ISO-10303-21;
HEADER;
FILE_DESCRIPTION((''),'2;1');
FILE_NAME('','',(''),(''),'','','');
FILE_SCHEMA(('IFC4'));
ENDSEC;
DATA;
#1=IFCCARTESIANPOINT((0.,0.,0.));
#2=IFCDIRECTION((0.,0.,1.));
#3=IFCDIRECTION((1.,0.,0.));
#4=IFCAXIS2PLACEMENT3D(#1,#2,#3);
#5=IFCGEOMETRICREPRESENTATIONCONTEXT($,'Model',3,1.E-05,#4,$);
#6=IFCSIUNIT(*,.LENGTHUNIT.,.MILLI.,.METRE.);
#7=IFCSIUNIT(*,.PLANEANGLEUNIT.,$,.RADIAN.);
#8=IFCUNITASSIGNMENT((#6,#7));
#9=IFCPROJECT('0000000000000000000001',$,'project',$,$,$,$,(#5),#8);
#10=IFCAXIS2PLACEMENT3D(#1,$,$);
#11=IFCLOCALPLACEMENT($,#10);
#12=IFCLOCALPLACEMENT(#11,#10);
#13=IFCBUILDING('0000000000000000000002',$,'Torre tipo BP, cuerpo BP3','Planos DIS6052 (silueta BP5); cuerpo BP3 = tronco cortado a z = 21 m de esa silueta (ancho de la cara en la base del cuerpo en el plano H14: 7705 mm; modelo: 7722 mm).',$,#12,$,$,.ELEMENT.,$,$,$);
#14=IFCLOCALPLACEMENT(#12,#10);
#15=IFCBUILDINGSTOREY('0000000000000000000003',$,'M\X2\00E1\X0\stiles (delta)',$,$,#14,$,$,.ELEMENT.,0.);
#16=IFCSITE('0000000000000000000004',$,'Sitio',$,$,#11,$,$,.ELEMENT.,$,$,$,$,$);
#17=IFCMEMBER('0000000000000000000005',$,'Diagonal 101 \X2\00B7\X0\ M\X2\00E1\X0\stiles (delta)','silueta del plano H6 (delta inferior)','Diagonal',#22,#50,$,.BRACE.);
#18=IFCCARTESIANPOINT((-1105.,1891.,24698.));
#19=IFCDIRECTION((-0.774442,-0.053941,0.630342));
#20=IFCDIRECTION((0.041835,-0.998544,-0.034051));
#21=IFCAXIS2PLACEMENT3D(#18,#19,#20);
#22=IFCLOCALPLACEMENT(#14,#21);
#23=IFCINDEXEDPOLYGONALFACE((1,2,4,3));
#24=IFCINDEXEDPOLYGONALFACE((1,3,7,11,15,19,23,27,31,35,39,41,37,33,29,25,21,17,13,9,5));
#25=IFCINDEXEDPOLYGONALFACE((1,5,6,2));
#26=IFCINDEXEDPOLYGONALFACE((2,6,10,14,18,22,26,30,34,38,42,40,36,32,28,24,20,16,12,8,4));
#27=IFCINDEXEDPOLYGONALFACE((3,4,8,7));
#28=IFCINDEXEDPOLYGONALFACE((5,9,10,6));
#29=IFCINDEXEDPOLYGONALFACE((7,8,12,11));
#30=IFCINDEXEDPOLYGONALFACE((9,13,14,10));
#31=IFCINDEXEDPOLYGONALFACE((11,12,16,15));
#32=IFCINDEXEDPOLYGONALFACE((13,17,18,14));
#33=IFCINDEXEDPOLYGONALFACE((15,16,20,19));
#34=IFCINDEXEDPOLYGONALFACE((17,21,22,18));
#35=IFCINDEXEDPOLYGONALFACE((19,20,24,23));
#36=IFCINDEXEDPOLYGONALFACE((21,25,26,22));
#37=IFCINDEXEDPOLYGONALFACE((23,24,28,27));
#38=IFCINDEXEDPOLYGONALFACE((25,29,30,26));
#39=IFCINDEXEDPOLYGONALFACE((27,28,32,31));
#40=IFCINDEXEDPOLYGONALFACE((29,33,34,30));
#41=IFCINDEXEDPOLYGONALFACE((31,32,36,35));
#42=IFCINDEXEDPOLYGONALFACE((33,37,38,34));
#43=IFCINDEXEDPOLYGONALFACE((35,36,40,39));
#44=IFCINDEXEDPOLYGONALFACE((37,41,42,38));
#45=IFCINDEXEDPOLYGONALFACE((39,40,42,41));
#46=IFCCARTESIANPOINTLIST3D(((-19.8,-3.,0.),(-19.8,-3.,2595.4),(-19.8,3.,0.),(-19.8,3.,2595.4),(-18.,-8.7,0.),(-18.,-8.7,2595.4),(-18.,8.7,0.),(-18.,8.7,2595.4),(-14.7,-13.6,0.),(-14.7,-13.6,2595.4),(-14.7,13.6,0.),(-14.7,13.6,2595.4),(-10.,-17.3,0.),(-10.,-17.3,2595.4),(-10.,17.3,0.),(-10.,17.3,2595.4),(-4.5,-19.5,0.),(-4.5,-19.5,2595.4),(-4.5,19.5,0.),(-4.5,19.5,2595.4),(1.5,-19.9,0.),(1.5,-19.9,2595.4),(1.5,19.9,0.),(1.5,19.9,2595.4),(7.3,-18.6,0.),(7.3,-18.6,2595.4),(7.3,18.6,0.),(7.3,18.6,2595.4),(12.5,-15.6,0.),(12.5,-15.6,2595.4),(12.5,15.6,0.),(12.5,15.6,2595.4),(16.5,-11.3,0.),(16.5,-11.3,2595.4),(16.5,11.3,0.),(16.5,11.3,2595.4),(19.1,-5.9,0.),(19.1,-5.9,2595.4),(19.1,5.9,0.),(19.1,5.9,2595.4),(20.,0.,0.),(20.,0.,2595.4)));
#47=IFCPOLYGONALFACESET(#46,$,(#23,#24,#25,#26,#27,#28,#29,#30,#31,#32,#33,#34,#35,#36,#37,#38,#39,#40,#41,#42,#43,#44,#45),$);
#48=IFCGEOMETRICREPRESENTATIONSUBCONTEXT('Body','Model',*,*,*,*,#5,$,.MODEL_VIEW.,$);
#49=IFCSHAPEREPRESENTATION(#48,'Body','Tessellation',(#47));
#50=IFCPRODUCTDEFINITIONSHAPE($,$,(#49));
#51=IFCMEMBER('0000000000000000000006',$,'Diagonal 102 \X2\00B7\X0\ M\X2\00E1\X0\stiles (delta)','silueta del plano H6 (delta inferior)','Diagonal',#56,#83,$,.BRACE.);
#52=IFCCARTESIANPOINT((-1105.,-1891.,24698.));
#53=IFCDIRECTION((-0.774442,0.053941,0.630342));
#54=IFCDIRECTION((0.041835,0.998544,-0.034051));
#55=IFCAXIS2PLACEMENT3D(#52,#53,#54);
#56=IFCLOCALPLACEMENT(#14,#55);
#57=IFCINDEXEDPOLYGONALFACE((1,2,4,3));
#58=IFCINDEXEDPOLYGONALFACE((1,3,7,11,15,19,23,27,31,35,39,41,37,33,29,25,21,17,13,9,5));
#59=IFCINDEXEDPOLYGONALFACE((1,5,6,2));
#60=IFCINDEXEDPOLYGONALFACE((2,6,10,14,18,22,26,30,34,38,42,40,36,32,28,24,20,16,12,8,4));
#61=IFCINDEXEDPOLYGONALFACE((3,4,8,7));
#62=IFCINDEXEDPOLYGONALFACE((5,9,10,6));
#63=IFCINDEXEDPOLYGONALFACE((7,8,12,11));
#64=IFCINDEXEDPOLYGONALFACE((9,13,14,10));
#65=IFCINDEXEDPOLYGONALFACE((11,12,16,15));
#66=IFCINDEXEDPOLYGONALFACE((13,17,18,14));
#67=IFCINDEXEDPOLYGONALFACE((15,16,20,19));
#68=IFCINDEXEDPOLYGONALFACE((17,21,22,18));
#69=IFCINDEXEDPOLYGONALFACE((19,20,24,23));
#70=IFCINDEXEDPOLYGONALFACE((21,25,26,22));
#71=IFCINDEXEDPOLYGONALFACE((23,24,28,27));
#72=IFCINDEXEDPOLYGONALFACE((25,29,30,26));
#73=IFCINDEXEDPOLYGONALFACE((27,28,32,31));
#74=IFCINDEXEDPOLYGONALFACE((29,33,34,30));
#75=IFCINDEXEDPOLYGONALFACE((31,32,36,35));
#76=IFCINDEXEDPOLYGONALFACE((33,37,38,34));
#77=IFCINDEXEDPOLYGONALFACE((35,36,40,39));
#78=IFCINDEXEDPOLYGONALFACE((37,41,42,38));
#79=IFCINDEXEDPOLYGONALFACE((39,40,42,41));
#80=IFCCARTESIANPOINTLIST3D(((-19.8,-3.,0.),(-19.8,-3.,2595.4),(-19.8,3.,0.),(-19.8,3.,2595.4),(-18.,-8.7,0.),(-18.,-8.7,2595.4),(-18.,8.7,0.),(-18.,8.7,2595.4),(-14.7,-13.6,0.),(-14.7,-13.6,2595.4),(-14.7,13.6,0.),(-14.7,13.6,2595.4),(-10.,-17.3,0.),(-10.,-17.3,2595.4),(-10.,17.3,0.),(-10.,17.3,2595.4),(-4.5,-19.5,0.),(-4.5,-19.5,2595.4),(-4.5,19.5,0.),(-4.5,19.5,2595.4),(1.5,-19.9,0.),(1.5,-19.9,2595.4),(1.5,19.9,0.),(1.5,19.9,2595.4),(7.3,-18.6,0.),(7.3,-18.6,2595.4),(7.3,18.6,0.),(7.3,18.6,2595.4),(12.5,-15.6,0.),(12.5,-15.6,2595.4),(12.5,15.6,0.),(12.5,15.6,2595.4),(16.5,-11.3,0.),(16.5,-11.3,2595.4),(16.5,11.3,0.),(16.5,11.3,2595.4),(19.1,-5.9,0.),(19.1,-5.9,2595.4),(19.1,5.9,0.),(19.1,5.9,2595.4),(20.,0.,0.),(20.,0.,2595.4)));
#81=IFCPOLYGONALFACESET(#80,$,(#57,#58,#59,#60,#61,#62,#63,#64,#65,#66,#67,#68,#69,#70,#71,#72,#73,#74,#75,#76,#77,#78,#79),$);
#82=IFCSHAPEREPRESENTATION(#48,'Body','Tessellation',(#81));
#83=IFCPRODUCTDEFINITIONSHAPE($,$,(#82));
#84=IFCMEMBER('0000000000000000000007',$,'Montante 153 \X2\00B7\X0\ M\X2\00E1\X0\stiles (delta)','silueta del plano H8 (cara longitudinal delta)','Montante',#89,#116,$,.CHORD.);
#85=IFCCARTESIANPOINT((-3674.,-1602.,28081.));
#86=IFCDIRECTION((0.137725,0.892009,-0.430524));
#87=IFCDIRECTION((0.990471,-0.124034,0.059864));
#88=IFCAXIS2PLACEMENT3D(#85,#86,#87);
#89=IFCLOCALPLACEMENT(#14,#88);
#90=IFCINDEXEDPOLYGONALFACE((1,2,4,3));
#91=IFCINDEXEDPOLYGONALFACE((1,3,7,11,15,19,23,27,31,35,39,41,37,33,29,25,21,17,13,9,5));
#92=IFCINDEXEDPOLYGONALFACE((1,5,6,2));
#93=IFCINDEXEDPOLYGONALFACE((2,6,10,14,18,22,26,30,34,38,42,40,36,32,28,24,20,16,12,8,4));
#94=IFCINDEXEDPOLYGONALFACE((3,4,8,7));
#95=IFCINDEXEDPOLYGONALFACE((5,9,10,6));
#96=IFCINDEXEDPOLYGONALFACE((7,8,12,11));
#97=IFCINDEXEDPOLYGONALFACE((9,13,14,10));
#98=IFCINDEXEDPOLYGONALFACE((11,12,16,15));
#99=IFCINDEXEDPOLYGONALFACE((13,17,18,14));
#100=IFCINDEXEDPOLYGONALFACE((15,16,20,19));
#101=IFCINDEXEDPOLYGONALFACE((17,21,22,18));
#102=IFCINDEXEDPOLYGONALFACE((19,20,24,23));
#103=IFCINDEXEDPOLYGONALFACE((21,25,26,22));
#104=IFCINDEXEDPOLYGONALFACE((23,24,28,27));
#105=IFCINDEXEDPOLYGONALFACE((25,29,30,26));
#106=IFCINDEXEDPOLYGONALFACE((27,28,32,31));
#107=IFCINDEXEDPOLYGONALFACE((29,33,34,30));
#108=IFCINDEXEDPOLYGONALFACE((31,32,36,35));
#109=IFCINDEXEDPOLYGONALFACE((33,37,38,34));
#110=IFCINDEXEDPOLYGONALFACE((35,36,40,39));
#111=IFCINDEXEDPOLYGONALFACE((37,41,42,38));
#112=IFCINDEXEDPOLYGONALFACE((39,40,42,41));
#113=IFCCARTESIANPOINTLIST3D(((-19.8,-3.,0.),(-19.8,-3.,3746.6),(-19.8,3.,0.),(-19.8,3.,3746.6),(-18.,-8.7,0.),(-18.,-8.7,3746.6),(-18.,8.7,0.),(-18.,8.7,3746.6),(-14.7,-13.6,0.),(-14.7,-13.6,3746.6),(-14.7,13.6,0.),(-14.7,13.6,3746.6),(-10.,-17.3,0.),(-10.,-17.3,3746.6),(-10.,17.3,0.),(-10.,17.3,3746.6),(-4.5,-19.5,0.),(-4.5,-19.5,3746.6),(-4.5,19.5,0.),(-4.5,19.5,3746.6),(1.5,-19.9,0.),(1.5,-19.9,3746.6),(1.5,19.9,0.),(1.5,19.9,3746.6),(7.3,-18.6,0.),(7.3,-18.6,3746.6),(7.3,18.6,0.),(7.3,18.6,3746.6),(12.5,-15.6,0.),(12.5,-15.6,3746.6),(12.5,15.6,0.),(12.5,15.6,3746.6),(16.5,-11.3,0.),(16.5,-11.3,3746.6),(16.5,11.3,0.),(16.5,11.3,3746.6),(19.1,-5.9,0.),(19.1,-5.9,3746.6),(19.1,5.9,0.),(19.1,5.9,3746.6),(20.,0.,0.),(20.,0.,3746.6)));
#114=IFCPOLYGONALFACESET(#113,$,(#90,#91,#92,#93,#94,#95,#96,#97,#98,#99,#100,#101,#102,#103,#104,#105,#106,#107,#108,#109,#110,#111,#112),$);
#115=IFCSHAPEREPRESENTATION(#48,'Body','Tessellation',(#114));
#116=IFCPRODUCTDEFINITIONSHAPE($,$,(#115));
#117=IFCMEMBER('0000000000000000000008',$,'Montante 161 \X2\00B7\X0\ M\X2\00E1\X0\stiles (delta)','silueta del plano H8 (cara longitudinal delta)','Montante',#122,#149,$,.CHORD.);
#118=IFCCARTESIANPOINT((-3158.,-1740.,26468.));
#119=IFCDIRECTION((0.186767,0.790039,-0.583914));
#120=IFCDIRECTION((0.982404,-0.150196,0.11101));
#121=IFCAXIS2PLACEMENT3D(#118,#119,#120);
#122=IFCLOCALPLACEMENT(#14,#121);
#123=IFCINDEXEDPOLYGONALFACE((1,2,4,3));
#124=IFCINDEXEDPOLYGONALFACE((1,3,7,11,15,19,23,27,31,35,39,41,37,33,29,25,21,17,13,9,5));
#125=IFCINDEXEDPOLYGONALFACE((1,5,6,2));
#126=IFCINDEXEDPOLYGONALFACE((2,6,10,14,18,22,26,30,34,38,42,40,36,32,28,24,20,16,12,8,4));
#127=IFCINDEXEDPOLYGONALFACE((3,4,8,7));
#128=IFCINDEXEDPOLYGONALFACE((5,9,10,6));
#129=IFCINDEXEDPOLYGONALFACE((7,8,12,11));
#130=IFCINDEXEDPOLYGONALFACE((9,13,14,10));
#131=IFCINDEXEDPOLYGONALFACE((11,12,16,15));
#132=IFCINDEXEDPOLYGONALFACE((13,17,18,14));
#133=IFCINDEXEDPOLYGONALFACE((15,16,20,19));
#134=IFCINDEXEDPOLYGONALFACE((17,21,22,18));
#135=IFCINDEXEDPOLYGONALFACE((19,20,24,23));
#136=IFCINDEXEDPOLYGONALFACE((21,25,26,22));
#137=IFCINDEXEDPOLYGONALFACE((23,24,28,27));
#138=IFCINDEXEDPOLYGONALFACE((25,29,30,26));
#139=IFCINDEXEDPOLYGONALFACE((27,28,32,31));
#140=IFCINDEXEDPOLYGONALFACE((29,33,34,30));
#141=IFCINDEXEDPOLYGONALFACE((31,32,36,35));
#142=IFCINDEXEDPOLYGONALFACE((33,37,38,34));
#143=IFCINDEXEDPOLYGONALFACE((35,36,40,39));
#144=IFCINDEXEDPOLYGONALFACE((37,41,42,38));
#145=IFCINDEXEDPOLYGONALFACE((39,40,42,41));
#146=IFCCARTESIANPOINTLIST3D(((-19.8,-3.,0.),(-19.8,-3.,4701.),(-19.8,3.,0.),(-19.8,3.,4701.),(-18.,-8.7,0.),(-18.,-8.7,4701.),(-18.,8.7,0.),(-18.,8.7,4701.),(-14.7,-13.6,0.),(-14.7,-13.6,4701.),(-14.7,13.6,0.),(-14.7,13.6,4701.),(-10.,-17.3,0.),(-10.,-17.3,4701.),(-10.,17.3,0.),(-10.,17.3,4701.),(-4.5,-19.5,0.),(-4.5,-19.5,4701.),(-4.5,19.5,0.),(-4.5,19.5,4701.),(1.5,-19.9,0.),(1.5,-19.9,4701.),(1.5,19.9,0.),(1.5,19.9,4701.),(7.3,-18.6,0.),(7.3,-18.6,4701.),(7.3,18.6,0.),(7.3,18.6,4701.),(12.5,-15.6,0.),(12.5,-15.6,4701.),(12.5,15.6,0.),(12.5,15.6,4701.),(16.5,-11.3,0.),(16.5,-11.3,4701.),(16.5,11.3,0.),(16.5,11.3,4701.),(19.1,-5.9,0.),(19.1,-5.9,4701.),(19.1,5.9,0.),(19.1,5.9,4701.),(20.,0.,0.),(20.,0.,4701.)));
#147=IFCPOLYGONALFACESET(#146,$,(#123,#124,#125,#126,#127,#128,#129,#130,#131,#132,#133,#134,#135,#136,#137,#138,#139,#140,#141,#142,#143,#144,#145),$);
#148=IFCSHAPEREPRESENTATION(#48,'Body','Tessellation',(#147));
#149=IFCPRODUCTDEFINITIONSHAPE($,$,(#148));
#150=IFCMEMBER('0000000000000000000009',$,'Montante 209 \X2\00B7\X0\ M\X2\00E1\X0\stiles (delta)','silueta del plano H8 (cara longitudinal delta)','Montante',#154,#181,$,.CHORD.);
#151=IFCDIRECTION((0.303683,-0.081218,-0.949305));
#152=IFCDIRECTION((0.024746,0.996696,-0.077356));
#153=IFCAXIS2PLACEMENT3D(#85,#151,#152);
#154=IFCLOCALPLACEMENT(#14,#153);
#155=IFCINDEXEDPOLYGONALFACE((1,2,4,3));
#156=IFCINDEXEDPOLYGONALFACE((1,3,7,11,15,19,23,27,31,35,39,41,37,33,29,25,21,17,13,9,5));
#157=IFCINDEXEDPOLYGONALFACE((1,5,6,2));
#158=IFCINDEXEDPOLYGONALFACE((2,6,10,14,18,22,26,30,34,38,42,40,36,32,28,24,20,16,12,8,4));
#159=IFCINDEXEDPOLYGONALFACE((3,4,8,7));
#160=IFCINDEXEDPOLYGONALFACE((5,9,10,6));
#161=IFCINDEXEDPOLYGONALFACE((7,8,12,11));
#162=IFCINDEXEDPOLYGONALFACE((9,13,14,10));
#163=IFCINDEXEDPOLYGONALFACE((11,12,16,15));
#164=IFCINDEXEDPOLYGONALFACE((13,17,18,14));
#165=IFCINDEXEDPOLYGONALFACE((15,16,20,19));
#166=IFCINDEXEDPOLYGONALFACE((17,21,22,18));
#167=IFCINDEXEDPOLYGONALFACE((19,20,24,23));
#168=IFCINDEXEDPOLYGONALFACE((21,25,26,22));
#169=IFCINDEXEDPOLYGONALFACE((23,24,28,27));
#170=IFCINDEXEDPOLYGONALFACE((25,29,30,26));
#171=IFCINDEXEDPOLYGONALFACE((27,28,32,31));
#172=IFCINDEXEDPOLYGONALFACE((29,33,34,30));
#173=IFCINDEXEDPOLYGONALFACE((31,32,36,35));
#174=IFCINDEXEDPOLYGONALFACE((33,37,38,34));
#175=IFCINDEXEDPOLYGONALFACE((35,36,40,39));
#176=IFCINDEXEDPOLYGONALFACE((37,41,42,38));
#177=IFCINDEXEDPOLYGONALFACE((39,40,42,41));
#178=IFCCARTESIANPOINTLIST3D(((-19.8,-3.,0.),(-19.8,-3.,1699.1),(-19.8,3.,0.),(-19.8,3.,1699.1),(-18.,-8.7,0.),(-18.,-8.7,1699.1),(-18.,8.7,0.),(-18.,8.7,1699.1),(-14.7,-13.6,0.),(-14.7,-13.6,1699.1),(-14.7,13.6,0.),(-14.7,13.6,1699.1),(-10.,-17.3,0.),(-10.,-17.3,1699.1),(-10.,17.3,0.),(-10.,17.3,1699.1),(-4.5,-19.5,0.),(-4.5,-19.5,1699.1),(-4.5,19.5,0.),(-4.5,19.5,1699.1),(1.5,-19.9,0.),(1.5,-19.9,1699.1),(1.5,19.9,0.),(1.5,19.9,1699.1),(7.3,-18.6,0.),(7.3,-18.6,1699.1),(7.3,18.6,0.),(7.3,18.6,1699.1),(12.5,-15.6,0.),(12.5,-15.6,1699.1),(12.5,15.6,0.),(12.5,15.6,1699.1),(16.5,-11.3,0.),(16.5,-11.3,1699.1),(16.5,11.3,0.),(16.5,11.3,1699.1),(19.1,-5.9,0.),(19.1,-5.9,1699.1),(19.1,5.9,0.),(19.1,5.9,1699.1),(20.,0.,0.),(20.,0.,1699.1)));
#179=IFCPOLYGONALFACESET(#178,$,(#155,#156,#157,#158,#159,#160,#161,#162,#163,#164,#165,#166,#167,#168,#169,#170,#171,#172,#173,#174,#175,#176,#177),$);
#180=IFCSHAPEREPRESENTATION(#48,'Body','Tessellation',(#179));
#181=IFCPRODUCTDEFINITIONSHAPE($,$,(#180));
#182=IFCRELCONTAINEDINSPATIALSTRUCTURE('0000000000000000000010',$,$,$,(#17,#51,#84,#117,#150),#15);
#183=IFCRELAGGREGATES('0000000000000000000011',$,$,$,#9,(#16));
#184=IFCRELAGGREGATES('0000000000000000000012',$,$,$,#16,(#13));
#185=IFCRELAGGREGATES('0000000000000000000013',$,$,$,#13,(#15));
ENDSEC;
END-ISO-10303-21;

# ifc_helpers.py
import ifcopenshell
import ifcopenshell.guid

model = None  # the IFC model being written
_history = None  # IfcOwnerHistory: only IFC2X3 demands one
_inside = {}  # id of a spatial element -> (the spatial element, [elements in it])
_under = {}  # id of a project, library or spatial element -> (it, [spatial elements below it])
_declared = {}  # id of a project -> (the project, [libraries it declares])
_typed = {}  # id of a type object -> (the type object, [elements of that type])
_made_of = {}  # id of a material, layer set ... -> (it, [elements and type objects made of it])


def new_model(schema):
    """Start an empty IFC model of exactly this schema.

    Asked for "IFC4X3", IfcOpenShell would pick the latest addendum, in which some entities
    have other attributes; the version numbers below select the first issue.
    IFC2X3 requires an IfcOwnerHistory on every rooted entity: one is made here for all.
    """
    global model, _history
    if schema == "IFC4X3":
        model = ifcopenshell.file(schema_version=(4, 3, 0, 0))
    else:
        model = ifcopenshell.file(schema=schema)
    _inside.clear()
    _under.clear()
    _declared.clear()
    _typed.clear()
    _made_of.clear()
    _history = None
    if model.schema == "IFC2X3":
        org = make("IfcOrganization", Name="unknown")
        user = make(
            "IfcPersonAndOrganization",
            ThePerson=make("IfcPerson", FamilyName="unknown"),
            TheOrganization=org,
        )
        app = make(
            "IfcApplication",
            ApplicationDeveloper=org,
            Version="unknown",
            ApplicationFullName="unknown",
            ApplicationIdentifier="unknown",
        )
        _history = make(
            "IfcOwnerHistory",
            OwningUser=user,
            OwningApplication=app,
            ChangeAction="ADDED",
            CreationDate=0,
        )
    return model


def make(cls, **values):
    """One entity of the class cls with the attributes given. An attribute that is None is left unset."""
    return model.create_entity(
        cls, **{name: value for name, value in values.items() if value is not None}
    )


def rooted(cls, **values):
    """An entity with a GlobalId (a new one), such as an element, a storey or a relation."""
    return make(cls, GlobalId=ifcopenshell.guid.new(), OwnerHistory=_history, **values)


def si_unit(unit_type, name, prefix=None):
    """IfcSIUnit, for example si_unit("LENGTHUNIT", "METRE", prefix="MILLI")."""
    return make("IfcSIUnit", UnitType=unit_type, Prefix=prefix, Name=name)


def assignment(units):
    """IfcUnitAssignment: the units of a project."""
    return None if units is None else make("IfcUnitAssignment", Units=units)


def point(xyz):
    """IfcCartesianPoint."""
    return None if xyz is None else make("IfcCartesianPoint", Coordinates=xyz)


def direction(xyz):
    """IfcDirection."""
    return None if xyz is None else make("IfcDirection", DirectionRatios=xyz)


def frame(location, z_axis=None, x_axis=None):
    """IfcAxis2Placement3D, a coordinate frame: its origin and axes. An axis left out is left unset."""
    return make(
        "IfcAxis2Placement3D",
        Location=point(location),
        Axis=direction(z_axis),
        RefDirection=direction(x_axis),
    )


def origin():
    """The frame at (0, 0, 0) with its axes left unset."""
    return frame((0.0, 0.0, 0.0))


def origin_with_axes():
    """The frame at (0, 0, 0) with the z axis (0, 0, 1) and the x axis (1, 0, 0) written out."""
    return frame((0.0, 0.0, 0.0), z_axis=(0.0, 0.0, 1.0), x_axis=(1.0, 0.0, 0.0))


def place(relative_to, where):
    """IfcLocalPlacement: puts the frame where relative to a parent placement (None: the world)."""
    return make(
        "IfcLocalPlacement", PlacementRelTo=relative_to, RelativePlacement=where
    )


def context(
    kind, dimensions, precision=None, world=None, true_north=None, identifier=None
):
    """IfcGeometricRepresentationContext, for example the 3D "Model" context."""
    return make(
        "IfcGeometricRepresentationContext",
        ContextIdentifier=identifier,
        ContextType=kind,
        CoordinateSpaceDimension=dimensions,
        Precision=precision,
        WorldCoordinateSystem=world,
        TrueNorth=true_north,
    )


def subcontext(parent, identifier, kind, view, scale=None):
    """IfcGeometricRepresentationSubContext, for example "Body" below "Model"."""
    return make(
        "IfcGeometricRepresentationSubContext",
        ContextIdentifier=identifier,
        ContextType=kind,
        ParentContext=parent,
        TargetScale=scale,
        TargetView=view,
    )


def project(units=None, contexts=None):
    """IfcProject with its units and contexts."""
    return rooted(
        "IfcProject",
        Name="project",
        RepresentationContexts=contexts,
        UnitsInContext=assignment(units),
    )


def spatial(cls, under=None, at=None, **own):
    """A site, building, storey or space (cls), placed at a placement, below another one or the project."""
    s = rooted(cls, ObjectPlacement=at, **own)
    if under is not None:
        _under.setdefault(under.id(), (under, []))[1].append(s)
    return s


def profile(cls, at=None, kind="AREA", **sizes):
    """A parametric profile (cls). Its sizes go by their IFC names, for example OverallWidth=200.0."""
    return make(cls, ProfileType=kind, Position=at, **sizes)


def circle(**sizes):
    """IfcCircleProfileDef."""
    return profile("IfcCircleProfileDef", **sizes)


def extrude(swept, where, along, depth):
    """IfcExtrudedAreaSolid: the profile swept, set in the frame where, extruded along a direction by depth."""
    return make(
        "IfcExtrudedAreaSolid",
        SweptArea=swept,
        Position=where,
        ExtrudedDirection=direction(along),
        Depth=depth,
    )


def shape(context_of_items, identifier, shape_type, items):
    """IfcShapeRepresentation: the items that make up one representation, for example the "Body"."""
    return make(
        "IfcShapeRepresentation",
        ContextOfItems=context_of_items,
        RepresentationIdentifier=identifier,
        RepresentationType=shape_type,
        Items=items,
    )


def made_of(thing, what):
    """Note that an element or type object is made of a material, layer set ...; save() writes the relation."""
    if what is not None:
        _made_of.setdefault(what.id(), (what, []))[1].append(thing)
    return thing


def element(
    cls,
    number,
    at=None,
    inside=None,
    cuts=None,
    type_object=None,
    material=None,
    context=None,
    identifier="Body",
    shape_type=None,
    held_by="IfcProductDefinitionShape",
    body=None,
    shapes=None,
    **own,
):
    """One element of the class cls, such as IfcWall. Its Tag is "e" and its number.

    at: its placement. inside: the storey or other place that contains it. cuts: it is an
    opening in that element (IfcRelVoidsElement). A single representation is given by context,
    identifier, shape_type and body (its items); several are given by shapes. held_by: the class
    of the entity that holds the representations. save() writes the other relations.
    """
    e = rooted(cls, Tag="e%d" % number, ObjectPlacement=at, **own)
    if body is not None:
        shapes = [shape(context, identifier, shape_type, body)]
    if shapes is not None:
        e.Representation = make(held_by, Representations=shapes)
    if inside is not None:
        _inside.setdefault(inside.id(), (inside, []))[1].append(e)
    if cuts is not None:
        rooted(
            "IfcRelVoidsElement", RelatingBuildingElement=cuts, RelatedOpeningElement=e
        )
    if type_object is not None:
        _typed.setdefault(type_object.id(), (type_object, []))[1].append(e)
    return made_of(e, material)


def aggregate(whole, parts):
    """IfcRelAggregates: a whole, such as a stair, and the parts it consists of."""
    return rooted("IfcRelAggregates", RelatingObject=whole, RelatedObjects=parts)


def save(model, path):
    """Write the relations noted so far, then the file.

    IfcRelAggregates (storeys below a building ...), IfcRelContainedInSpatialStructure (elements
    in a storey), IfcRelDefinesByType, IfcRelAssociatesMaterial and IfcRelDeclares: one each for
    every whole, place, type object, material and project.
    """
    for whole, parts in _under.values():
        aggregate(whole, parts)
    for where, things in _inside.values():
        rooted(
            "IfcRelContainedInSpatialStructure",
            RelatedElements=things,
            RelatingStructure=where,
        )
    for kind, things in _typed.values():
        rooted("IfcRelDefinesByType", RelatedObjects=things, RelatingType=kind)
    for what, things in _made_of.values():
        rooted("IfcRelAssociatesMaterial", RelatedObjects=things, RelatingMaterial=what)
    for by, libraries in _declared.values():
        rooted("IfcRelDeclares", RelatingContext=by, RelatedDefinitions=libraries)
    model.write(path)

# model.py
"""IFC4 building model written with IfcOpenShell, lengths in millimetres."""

from ifc_helpers import new_model, si_unit, frame, origin, origin_with_axes, place, context, subcontext, project, spatial, circle, extrude, element, save


model = new_model("IFC4")

# Units and contexts
model_context = context("Model", 3, precision=1e-05, world=origin_with_axes())
body_context = subcontext(model_context, "Body", "Model", "MODEL_VIEW")
ifc_project = project(units=[si_unit("LENGTHUNIT", "METRE", prefix="MILLI"), si_unit("PLANEANGLEUNIT", "RADIAN")], contexts=[model_context])

# Site, building, storey
site_placement = place(None, origin())
site = spatial("IfcSite", under=ifc_project, at=site_placement, Name="Sitio", CompositionType="ELEMENT")
building_placement = place(site_placement, origin())
building = spatial("IfcBuilding", under=site, at=building_placement, Name="Torre tipo BP, cuerpo BP3", Description="Planos DIS6052 (silueta BP5); cuerpo BP3 = tronco cortado a z = 21 m de esa silueta (ancho de la cara en la base del cuerpo en el plano H14: 7705 mm; modelo: 7722 mm).", CompositionType="ELEMENT")
storey_placement = place(building_placement, origin())
storey = spatial("IfcBuildingStorey", under=building, at=storey_placement, Name="Mástiles (delta)", CompositionType="ELEMENT", Elevation=0.0)

# Members
for number, where, z_axis, x_axis, name in (
    (1, (-1105.0, 1891.0, 24698.0), (-0.774442, -0.053941, 0.630342), (0.041835, -0.998544, -0.034051), "Diagonal 101 · Mástiles (delta)"),
    (2, (-1105.0, -1891.0, 24698.0), (-0.774442, 0.053941, 0.630342), (0.041835, 0.998544, -0.034051), "Diagonal 102 · Mástiles (delta)"),
):
    element("IfcMember", number, at=place(storey_placement, frame(where, z_axis=z_axis, x_axis=x_axis)), inside=storey, Name=name, Description="silueta del plano H6 (delta inferior)", ObjectType="Diagonal", PredefinedType="BRACE", context=body_context, shape_type="SweptSolid", body=[
        extrude(circle(Radius=20.0), None, (0.0, 0.0, 1.0), 2595.4),
    ])
member_1_placement = place(storey_placement, frame((-3674.0, -1602.0, 28081.0), z_axis=(0.137725, 0.892009, -0.430524), x_axis=(0.990471, -0.124034, 0.059864)))
element("IfcMember", 3, at=member_1_placement, inside=storey, Name="Montante 153 · Mástiles (delta)", Description="silueta del plano H8 (cara longitudinal delta)", ObjectType="Montante", PredefinedType="CHORD", context=body_context, shape_type="SweptSolid", body=[
    extrude(circle(Radius=20.0), None, (0.0, 0.0, 1.0), 3746.6),
])
for number, where, z_axis, x_axis, name in (
    (4, (-3158.0, -1740.0, 26468.0), (0.186767, 0.790039, -0.583914), (0.982404, -0.150196, 0.11101), "Montante 161 · Mástiles (delta)"),
):
    element("IfcMember", number, at=place(storey_placement, frame(where, z_axis=z_axis, x_axis=x_axis)), inside=storey, Name=name, Description="silueta del plano H8 (cara longitudinal delta)", ObjectType="Montante", PredefinedType="CHORD", context=body_context, shape_type="SweptSolid", body=[
        extrude(circle(Radius=20.0), None, (0.0, 0.0, 1.0), 4701.0),
    ])
for number, where, z_axis, x_axis, name in (
    (5, (-3674.0, -1602.0, 28081.0), (0.303683, -0.081218, -0.949305), (0.024746, 0.996696, -0.077356), "Montante 209 · Mástiles (delta)"),
):
    element("IfcMember", number, at=place(storey_placement, frame(where, z_axis=z_axis, x_axis=x_axis)), inside=storey, Name=name, Description="silueta del plano H8 (cara longitudinal delta)", ObjectType="Montante", PredefinedType="CHORD", context=body_context, shape_type="SweptSolid", body=[
        extrude(circle(Radius=20.0), None, (0.0, 0.0, 1.0), 1699.1),
    ])

save(model, "model.ifc")
